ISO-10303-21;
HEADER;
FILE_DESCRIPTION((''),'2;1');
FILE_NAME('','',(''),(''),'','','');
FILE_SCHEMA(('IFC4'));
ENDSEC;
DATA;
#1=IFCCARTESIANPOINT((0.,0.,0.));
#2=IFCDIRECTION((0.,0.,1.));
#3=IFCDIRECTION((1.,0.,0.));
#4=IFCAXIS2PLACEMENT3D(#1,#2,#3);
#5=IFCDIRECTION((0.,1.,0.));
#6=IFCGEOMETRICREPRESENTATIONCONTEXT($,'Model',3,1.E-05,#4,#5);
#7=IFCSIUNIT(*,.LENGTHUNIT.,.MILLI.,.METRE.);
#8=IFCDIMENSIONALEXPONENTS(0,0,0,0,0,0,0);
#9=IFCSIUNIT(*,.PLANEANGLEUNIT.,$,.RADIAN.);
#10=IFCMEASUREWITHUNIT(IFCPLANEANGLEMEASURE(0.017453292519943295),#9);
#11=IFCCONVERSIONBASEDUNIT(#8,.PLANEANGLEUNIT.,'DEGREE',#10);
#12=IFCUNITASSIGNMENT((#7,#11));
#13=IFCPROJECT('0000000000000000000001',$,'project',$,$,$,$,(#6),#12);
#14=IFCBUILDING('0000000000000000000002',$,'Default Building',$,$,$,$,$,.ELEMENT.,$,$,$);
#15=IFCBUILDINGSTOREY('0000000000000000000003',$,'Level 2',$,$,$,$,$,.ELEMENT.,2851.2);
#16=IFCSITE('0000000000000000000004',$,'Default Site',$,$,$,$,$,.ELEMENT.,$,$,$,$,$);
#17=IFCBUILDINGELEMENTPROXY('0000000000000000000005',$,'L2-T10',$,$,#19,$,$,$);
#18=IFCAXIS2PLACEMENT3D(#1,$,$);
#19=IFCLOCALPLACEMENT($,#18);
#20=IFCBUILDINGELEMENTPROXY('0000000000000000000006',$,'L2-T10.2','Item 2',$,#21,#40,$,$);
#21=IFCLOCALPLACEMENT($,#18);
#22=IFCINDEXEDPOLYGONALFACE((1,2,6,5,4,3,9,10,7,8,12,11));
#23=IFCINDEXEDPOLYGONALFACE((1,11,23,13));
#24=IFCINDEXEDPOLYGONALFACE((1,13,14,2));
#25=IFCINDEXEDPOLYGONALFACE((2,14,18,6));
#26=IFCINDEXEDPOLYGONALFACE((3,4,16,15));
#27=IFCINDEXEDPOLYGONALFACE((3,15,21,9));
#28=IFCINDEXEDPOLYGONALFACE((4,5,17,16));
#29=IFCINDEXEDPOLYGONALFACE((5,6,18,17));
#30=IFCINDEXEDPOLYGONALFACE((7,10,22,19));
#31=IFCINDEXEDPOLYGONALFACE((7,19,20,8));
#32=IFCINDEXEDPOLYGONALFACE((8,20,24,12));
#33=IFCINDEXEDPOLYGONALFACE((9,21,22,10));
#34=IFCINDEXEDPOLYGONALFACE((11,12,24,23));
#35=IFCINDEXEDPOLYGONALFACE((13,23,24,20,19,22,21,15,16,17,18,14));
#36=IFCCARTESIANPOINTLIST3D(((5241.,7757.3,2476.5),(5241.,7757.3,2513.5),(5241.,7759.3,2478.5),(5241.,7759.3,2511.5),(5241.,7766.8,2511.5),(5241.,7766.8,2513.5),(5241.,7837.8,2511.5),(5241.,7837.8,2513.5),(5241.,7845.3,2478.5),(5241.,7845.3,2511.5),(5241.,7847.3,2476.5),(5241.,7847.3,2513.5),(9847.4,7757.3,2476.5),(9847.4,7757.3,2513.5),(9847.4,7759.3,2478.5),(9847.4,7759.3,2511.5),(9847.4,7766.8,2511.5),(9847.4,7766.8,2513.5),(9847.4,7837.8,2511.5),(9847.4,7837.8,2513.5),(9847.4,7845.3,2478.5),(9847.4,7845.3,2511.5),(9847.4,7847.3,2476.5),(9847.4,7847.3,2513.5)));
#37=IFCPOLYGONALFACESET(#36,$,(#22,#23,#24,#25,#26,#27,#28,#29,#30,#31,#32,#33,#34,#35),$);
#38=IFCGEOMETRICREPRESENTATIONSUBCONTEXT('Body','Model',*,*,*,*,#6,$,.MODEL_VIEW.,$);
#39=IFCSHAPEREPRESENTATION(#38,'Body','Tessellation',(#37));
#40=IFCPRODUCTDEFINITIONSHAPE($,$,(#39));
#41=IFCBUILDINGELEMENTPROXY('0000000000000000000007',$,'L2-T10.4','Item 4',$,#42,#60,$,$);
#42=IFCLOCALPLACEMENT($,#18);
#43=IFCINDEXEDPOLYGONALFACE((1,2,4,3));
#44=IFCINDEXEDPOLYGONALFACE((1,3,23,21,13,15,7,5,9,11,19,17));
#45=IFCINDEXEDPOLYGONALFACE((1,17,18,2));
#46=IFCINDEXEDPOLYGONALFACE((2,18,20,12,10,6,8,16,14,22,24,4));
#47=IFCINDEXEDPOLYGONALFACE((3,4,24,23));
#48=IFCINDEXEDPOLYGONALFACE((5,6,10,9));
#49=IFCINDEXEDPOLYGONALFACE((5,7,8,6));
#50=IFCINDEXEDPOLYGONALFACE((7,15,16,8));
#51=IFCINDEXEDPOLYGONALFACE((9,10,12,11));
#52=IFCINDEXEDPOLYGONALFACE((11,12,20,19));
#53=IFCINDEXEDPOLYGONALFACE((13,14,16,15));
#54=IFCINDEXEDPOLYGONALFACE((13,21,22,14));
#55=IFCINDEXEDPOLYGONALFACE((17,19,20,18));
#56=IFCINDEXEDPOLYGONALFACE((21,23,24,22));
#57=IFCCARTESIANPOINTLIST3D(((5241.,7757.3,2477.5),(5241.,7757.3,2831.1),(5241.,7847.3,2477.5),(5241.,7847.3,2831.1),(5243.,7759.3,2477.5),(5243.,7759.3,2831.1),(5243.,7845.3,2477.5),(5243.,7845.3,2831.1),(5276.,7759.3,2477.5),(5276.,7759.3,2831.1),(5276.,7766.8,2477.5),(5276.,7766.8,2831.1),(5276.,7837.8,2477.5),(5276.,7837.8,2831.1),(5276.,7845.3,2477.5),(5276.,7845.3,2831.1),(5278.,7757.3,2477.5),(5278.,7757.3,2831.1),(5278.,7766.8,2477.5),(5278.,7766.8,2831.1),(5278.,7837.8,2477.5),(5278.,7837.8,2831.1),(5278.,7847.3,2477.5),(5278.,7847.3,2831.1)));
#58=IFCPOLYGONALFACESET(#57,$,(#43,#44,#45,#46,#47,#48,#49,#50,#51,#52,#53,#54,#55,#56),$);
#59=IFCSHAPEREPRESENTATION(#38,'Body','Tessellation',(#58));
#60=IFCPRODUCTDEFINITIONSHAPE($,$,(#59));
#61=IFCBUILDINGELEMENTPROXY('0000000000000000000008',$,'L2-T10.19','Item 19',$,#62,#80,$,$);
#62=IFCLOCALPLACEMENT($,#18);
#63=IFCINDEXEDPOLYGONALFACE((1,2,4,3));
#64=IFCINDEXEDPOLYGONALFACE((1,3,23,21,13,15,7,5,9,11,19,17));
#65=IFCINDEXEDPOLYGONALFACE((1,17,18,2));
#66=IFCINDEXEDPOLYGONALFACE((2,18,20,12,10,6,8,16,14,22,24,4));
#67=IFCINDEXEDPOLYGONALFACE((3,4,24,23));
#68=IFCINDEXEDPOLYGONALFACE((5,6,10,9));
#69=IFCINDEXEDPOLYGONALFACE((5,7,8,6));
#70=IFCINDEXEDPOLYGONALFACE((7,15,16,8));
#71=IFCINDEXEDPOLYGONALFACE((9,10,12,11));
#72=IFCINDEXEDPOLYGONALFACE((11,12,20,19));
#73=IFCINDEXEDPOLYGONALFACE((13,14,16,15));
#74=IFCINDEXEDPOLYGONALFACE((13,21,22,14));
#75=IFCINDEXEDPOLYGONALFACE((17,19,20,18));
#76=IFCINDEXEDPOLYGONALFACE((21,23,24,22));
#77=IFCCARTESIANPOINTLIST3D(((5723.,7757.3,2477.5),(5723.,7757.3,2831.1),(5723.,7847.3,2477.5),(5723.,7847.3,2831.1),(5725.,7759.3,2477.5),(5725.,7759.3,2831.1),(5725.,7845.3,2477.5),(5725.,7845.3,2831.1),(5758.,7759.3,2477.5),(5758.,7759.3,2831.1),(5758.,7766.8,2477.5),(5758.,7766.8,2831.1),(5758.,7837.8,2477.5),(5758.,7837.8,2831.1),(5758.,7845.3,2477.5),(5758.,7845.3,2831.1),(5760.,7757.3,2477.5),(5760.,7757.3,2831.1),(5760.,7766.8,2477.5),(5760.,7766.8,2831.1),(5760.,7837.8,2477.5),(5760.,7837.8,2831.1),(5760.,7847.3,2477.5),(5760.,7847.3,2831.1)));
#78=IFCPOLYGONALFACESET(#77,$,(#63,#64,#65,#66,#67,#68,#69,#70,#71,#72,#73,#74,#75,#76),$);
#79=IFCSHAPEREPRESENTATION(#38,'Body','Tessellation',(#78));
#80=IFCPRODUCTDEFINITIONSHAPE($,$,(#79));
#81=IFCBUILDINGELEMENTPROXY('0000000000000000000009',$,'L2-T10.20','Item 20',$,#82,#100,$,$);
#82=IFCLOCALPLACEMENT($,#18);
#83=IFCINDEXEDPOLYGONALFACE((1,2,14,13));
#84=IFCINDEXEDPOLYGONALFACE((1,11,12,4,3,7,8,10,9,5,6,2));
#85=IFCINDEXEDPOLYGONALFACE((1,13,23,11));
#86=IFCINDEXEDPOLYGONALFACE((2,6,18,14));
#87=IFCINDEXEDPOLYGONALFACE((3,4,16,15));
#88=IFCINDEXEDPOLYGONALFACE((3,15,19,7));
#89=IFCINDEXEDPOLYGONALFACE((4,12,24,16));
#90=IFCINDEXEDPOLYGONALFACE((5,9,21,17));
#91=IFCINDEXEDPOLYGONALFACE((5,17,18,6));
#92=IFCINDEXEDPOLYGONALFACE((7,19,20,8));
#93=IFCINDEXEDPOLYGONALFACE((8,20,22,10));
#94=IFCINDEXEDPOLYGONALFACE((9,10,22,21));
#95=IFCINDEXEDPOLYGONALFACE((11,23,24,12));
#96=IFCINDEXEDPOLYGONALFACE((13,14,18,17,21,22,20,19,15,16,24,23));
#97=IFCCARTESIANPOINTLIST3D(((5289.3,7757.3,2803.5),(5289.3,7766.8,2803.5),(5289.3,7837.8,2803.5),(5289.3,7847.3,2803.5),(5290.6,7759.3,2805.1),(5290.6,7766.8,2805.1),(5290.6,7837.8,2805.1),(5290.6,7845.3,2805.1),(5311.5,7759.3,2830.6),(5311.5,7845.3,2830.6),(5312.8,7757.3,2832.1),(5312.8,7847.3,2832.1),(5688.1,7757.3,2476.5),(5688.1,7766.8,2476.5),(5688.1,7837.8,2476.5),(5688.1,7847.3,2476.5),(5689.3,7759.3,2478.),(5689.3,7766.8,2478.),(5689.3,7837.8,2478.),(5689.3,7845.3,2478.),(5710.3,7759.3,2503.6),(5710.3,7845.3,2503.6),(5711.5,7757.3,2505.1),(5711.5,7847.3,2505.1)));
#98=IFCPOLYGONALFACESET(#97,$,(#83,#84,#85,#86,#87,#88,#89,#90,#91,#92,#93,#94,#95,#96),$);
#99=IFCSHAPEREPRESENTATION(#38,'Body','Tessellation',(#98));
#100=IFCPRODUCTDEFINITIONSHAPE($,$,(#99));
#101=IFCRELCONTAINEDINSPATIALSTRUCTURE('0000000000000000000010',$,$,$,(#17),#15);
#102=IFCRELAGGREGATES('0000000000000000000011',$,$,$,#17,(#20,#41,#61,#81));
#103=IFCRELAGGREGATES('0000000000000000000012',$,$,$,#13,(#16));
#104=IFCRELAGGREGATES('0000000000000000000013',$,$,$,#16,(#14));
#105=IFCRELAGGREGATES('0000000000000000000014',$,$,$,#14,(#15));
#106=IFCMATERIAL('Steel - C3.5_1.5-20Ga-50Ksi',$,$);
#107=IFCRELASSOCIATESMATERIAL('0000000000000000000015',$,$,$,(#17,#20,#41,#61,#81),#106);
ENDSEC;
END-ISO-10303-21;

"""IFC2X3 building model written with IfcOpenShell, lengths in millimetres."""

from ifc_helpers import new_model, entity, si_unit, converted_unit, direction, frame, origin, origin_with_axes, origin_2d_with_axis, place, context, subcontext, project, spatial, c_section, extrude, material, element, aggregate, save


model = new_model("IFC2X3")

# Units and contexts
model_context = context("Model", 3, precision=1e-05, world=origin_with_axes(), true_north=direction((0.0, 1.0, 0.0)))
body_context = subcontext(model_context, "Body", "Model", "MODEL_VIEW")
ifc_project = project(units=[si_unit("LENGTHUNIT", "METRE", prefix="MILLI"), converted_unit("PLANEANGLEUNIT", "DEGREE", entity("IfcPlaneAngleMeasure", 0.017453292519943295), si_unit("PLANEANGLEUNIT", "RADIAN"), dimensions=[0, 0, 0, 0, 0, 0, 0])], contexts=[model_context])

# Site, building, storey
site = spatial("IfcSite", under=ifc_project, Name="Default Site", CompositionType="ELEMENT")
building = spatial("IfcBuilding", under=site, Name="Default Building", CompositionType="ELEMENT")
storey = spatial("IfcBuildingStorey", under=building, Name="Level 2", CompositionType="ELEMENT", Elevation=2851.2)

# Shared definitions
ifc_material_1 = material(Name="Steel - C3.5_1.5-20Ga-50Ksi")

# Building element proxies
proxy_1 = element("IfcBuildingElementProxy", 1, inside=storey, material=ifc_material_1, Name="L2-T10")
proxy_2_placement = place(None, frame((5241.0, 7802.3, 2495.0), z_axis=(1.0, 0.0, 0.0), x_axis=(0.0, 0.0, 37.0)))
proxy_2 = element("IfcBuildingElementProxy", 2, at=proxy_2_placement, material=ifc_material_1, Name="L2-T10.2", Description="Item 2", context=body_context, shape_type="SweptSolid", body=[
    extrude(c_section(Depth=90.0, Width=37.0, WallThickness=2.0, Girth=9.5, at=origin_2d_with_axis()), origin(), (0.0, 0.0, 1.0), 4606.4),
])
proxy_3_placement = place(None, frame((5259.5, 7802.3, 2831.1), z_axis=(0.0, 0.0, -1.0), x_axis=(37.0, 0.0, 0.0)))
proxy_3 = element("IfcBuildingElementProxy", 3, at=proxy_3_placement, material=ifc_material_1, Name="L2-T10.4", Description="Item 4", context=body_context, shape_type="SweptSolid", body=[
    extrude(c_section(Depth=90.0, Width=37.0, WallThickness=2.0, Girth=9.5, at=origin_2d_with_axis()), origin(), (0.0, 0.0, 1.0), 353.6),
])
proxy_4_placement = place(None, frame((5741.5, 7802.3, 2831.1), z_axis=(0.0, 0.0, -1.0), x_axis=(37.0, 0.0, -0.004)))
proxy_4 = element("IfcBuildingElementProxy", 4, at=proxy_4_placement, material=ifc_material_1, Name="L2-T10.19", Description="Item 19", context=body_context, shape_type="SweptSolid", body=[
    extrude(c_section(Depth=90.0, Width=37.0, WallThickness=2.0, Girth=9.5, at=origin_2d_with_axis()), origin(), (0.0, 0.0, 1.0), 353.6),
])
proxy_5_placement = place(None, frame((5699.8, 7802.3, 2490.8), z_axis=(-0.773, 0.0, 0.634), x_axis=(-23.462, 0.0, -28.61)))
proxy_5 = element("IfcBuildingElementProxy", 5, at=proxy_5_placement, material=ifc_material_1, Name="L2-T10.20", Description="Item 20", context=body_context, shape_type="SweptSolid", body=[
    extrude(c_section(Depth=90.0, Width=37.0, WallThickness=2.0, Girth=9.5, at=origin_2d_with_axis()), origin(), (0.0, 0.0, 1.0), 515.7),
])
aggregate(proxy_1, [proxy_2, proxy_3, proxy_4, proxy_5])

save(model, "model.ifc")
